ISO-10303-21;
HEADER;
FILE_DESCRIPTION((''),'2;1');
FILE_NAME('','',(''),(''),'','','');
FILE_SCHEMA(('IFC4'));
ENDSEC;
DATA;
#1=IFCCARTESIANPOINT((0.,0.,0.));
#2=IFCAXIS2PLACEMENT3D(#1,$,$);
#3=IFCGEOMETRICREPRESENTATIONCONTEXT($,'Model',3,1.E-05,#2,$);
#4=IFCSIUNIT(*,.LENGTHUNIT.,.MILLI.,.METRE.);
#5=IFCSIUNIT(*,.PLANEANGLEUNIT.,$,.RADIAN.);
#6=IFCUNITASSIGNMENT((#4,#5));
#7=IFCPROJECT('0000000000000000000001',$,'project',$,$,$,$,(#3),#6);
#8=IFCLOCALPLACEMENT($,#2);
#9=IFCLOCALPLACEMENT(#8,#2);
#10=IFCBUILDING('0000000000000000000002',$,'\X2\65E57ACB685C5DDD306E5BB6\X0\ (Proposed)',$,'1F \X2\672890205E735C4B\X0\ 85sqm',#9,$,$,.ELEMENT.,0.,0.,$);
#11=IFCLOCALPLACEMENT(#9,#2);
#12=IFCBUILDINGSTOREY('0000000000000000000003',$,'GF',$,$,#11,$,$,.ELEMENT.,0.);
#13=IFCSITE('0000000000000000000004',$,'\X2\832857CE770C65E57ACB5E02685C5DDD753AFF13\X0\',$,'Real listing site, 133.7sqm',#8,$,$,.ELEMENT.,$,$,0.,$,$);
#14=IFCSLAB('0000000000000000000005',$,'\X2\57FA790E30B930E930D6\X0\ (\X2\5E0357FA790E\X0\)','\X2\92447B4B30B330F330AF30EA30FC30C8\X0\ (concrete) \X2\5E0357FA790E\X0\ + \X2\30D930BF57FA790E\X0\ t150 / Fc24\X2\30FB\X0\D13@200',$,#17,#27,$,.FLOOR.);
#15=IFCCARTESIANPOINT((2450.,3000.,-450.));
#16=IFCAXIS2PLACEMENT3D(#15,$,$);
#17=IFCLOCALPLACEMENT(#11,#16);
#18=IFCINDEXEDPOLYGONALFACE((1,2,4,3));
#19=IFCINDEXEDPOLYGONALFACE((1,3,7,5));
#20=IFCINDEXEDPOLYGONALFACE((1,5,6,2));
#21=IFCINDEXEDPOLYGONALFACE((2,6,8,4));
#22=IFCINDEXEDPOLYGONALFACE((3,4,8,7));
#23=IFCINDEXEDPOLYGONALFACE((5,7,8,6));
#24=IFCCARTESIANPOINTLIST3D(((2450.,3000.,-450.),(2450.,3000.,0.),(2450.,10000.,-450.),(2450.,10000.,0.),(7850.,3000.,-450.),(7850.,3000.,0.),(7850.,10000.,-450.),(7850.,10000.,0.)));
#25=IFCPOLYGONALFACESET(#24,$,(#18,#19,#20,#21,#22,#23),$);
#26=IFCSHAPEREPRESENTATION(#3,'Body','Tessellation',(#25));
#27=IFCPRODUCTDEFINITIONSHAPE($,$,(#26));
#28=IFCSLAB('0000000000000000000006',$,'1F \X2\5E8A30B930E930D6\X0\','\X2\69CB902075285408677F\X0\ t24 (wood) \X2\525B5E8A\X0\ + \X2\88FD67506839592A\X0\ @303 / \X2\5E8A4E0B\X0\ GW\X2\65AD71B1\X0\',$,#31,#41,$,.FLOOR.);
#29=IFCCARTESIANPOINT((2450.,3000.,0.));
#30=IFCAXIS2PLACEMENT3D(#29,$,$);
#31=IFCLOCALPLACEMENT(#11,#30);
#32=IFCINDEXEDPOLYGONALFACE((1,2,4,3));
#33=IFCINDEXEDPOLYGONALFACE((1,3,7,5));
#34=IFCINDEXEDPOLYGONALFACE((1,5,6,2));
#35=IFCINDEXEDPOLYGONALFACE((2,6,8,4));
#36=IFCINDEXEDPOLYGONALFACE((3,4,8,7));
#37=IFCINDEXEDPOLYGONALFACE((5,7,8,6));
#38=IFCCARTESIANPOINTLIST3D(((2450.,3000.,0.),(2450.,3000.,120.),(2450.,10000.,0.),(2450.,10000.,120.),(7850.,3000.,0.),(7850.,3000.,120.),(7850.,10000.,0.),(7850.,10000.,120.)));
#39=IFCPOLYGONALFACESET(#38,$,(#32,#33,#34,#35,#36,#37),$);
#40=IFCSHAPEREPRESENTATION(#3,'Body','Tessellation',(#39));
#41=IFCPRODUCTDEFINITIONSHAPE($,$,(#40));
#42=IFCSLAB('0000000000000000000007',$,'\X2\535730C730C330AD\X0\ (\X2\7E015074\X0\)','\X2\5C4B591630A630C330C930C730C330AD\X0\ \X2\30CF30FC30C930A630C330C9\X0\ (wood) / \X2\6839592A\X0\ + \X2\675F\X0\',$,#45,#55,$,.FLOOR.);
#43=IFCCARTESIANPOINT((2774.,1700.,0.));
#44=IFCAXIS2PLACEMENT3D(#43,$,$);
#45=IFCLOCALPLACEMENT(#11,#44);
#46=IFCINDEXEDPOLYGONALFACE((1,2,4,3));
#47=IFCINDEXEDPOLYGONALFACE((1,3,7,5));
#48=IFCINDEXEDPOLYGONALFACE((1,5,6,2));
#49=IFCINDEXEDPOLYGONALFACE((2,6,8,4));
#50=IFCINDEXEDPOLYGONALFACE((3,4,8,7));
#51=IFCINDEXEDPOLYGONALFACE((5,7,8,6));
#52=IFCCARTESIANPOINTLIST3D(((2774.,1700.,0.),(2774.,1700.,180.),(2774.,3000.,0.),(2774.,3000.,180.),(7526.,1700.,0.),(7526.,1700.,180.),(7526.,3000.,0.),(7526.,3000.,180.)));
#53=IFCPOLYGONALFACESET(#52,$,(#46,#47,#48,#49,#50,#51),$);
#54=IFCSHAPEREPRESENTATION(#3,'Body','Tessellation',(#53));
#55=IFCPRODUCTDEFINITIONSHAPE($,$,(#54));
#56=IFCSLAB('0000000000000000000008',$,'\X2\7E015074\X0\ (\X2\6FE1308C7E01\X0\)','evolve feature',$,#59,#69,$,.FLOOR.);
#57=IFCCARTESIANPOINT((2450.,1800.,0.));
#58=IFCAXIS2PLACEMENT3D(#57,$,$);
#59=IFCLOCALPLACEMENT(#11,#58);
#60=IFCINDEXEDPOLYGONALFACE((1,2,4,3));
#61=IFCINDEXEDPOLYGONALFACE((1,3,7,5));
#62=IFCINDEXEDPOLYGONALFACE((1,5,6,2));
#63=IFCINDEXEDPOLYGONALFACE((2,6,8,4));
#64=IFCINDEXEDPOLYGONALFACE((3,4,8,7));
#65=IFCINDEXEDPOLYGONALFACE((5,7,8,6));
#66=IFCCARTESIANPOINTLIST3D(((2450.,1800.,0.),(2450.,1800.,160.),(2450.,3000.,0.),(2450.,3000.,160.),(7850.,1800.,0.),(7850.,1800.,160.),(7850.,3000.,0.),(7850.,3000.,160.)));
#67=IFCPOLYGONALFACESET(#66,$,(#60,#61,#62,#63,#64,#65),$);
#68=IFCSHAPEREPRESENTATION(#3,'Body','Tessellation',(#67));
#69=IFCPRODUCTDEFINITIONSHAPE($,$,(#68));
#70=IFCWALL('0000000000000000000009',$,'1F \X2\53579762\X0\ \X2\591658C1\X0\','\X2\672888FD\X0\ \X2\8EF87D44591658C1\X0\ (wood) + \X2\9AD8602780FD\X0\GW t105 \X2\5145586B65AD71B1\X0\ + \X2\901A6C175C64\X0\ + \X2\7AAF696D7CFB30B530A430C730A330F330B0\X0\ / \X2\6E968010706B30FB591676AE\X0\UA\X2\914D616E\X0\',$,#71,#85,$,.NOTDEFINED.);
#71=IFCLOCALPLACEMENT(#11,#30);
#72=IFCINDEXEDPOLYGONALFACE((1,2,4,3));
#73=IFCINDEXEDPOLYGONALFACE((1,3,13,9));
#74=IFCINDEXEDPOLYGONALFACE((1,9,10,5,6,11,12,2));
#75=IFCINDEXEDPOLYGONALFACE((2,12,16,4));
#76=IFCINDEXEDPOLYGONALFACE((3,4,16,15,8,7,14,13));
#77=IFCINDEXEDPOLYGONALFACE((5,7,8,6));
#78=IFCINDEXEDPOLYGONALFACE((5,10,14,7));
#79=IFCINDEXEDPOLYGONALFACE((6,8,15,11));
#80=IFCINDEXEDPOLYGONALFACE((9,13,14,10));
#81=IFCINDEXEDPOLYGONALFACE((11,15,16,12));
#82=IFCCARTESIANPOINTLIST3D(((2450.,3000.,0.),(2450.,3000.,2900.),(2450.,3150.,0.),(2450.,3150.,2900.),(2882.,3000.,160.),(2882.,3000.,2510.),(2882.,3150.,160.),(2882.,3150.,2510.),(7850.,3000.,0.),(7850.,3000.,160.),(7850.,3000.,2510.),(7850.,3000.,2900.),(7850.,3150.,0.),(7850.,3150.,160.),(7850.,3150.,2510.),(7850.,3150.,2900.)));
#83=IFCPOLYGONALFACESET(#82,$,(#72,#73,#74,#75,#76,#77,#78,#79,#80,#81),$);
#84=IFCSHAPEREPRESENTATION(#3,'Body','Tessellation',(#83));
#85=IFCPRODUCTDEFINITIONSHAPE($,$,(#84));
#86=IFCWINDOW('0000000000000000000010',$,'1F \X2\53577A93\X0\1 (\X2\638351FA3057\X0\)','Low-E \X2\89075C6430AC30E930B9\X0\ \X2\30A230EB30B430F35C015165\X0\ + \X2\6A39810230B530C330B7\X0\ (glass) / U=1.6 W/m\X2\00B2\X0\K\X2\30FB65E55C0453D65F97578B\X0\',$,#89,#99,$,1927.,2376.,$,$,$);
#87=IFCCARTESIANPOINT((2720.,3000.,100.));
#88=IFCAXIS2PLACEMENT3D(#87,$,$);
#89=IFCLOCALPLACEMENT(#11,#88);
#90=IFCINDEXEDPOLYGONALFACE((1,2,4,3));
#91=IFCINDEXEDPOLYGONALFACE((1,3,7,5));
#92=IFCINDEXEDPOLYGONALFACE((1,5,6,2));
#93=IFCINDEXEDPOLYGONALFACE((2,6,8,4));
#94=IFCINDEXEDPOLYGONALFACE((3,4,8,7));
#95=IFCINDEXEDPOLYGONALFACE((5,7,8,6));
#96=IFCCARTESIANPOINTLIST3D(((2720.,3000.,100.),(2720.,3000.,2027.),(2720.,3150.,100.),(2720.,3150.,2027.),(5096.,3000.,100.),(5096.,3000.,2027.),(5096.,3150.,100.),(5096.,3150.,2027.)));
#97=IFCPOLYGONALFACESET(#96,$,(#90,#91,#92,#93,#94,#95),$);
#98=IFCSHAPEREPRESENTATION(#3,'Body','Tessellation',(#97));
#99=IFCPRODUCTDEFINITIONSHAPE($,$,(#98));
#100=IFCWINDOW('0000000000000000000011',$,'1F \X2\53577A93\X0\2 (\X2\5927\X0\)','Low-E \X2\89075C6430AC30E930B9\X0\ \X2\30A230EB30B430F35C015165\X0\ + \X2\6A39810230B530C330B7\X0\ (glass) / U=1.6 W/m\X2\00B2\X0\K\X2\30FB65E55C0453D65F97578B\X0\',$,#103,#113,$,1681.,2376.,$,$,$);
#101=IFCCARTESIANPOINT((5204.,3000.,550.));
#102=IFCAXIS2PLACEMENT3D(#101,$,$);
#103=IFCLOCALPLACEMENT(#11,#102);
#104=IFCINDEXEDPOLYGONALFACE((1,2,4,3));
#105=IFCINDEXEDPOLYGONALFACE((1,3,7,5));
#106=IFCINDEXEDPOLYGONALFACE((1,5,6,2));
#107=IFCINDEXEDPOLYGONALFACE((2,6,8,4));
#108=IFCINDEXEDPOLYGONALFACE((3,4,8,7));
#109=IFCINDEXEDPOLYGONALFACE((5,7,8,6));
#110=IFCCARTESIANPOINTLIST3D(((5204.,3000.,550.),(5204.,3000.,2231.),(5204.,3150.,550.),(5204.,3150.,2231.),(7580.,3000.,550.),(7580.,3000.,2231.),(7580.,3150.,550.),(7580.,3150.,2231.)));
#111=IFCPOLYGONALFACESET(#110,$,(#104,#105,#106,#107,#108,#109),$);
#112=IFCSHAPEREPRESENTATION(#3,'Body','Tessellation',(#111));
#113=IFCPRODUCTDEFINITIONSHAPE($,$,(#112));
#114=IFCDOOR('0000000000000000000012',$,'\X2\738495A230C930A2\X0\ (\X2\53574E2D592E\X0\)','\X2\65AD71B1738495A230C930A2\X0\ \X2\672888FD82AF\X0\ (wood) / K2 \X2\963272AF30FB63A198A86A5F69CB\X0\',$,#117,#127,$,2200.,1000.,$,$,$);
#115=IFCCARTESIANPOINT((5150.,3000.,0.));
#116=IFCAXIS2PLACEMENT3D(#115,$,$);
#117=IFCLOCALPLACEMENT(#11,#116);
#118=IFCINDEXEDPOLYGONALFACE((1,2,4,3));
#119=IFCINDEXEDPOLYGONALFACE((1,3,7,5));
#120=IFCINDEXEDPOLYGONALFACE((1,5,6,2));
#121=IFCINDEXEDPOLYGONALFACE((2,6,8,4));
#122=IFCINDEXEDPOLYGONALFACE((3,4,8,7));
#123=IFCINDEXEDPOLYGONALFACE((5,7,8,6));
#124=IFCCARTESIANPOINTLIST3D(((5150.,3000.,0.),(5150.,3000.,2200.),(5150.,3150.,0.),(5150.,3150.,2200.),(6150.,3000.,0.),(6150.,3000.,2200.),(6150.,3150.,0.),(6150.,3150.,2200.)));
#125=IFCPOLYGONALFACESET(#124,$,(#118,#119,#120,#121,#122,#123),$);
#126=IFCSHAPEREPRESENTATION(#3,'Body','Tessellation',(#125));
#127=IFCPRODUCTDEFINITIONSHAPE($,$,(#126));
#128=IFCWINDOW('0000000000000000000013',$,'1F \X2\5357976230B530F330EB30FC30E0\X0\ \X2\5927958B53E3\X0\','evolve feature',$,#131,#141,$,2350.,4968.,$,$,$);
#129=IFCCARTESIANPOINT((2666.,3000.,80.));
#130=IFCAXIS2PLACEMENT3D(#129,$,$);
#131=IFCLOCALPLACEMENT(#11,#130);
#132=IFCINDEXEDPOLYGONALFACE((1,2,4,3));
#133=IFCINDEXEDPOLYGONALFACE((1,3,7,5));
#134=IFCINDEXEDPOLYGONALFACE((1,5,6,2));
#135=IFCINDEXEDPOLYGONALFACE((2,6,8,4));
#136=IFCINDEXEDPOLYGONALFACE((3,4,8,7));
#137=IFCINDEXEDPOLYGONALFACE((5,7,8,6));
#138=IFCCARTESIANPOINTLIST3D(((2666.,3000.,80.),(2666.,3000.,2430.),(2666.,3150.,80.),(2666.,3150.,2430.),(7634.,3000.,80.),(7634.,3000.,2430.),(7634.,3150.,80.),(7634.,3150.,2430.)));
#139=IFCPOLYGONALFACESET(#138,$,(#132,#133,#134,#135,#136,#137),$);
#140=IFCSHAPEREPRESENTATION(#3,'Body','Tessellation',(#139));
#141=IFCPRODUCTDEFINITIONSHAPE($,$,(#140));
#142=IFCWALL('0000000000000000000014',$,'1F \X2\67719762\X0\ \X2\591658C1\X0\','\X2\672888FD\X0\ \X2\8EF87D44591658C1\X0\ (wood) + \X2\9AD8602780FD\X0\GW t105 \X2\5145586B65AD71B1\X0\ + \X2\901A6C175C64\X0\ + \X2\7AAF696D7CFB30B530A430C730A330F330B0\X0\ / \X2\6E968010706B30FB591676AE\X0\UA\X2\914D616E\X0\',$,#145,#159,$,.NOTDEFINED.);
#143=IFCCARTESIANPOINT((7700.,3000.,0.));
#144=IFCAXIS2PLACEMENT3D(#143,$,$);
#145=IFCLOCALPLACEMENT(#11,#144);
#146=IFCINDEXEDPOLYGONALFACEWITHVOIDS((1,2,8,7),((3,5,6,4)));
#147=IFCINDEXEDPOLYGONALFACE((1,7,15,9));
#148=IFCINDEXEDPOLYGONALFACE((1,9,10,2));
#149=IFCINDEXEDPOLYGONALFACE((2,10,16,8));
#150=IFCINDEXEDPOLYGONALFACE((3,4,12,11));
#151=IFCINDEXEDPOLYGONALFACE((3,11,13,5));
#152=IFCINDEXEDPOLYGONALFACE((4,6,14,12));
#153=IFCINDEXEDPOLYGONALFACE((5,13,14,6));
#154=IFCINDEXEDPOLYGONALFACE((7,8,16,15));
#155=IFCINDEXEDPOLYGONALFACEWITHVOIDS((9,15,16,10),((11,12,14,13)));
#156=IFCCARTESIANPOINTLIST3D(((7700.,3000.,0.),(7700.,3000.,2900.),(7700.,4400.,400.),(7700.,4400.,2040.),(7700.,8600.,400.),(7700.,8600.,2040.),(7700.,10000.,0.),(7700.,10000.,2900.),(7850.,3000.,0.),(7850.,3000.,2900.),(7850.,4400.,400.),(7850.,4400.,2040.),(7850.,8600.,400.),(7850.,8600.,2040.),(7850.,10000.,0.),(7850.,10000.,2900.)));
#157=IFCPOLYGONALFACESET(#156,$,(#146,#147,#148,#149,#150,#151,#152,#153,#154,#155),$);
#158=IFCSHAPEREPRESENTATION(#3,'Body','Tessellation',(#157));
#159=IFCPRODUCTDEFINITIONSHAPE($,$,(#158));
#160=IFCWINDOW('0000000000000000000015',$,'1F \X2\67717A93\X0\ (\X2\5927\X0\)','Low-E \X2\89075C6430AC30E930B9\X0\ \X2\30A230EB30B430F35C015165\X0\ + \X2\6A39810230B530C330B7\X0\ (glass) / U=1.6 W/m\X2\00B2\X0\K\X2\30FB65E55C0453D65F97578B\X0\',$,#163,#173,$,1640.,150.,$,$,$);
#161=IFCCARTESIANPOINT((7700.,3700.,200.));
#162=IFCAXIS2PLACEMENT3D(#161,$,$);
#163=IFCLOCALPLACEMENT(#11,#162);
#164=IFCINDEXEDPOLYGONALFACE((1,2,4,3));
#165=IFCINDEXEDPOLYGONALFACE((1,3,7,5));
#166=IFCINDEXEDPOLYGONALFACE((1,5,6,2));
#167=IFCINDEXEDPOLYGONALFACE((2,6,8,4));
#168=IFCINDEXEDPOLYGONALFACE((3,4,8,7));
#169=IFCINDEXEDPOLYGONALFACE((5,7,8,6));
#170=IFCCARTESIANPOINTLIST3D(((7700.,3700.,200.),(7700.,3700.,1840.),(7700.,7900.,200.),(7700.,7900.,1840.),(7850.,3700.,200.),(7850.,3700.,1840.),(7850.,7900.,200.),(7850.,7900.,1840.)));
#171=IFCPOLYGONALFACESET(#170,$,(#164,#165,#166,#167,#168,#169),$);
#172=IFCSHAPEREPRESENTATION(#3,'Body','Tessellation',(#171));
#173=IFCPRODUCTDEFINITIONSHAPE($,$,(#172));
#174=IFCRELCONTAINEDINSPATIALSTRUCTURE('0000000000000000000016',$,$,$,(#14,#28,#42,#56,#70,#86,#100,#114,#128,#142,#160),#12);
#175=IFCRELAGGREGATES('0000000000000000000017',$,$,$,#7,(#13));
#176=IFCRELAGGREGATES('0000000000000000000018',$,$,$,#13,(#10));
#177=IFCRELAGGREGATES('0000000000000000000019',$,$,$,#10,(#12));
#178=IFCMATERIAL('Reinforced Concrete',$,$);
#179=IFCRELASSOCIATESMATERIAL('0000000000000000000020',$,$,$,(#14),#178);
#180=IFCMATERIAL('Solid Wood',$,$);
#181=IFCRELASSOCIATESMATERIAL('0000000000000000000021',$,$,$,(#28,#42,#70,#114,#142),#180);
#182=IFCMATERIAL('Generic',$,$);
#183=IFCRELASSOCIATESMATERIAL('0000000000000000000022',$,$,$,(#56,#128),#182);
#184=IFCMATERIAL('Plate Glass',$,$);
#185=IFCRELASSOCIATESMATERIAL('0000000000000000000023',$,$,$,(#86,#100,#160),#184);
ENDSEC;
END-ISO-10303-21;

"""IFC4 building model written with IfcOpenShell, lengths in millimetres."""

from ifc_helpers import new_model, si_unit, frame, frame_2d, origin, place, context, project, spatial, rectangle, extrude, material, element, fill, save


model = new_model("IFC4")

# Units and contexts
model_context = context("Model", 3, precision=1e-05, world=origin())
ifc_project = project(units=[si_unit("LENGTHUNIT", "METRE", prefix="MILLI"), si_unit("PLANEANGLEUNIT", "RADIAN")], contexts=[model_context])

# Site, building, storey
site_placement = place(None, origin())
site = spatial("IfcSite", under=ifc_project, at=site_placement, Name="茨城県日立市桜川町３", ObjectType="Real listing site, 133.7sqm", CompositionType="ELEMENT", RefElevation=0.0)
building_placement = place(site_placement, origin())
building = spatial("IfcBuilding", under=site, at=building_placement, Name="日立桜川の家 (Proposed)", ObjectType="1F 木造平屋 85sqm", CompositionType="ELEMENT", ElevationOfRefHeight=0.0, ElevationOfTerrain=0.0)
storey_placement = place(building_placement, origin())
storey = spatial("IfcBuildingStorey", under=building, at=storey_placement, Name="GF", CompositionType="ELEMENT", Elevation=0.0)

# Slabs
ifc_material_1 = material(Name="Reinforced Concrete")
slab_1_placement = place(storey_placement, frame((2450.0, 3000.0, -450.0)))
element("IfcSlab", 1, at=slab_1_placement, inside=storey, material=ifc_material_1, Name="基礎スラブ (布基礎)", Description="鉄筋コンクリート (concrete) 布基礎 + ベタ基礎 t150 / Fc24・D13@200", PredefinedType="FLOOR", context=model_context, shape_type="SweptSolid", body=[
    extrude(rectangle(XDim=5400.0, YDim=7000.0, at=frame_2d((2700.0, 3500.0))), frame((2450.0, 3000.0, -450.0)), (0.0, 0.0, 1.0), 450.0),
])
ifc_material_2 = material(Name="Solid Wood")
slab_2_placement = place(storey_placement, frame((2450.0, 3000.0, 0.0)))
element("IfcSlab", 2, at=slab_2_placement, inside=storey, material=ifc_material_2, Name="1F 床スラブ", Description="構造用合板 t24 (wood) 剛床 + 製材根太 @303 / 床下 GW断熱", PredefinedType="FLOOR", context=model_context, shape_type="SweptSolid", body=[
    extrude(rectangle(XDim=5400.0, YDim=7000.0, at=frame_2d((2700.0, 3500.0))), frame((2450.0, 3000.0, 0.0)), (0.0, 0.0, 1.0), 120.0),
])
slab_3_placement = place(storey_placement, frame((2774.0, 1700.0, 0.0)))
element("IfcSlab", 3, at=slab_3_placement, inside=storey, material=ifc_material_2, Name="南デッキ (縁側)", Description="屋外ウッドデッキ ハードウッド (wood) / 根太 + 束", PredefinedType="FLOOR", context=model_context, shape_type="SweptSolid", body=[
    extrude(rectangle(XDim=4752.0, YDim=1300.0, at=frame_2d((2376.0, 650.0))), frame((2774.0, 1700.0, 0.0)), (0.0, 0.0, 1.0), 180.0),
])
ifc_material_3 = material(Name="Generic")
slab_4_placement = place(storey_placement, frame((2450.0, 1800.0, 0.0)))
element("IfcSlab", 4, at=slab_4_placement, inside=storey, material=ifc_material_3, Name="縁側 (濡れ縁)", Description="evolve feature", PredefinedType="FLOOR", context=model_context, shape_type="SweptSolid", body=[
    extrude(rectangle(XDim=5400.0, YDim=1200.0, at=frame_2d((2700.0, 600.0))), frame((2450.0, 1800.0, 0.0)), (0.0, 0.0, 1.0), 160.0),
])

# Wall, openings, windows, door
wall_1_placement = place(storey_placement, frame((2450.0, 3000.0, 0.0)))
wall_1 = element("IfcWall", 5, at=wall_1_placement, inside=storey, material=ifc_material_2, Name="1F 南面 外壁", Description="木製 軸組外壁 (wood) + 高性能GW t105 充填断熱 + 通気層 + 窯業系サイディング / 準耐火・外皮UA配慮", PredefinedType="NOTDEFINED", context=model_context, shape_type="SweptSolid", body=[
    extrude(rectangle(XDim=5400.0, YDim=150.0, at=frame_2d((2700.0, 75.0))), frame((2450.0, 3000.0, 0.0)), (0.0, 0.0, 1.0), 2900.0),
])
opening_1_placement = place(storey_placement, frame((2720.0, 3000.0, 100.0)))
opening_1 = element("IfcOpeningElement", 6, at=opening_1_placement, cuts=wall_1, PredefinedType="NOTDEFINED", context=model_context, shape_type="SweptSolid", body=[
    extrude(rectangle(XDim=2376.0, YDim=150.0, at=frame_2d((1188.0, 75.0))), frame((2720.0, 3000.0, 100.0)), (0.0, 0.0, 1.0), 1927.0),
])
opening_2_placement = place(storey_placement, frame((5204.0, 3000.0, 550.0)))
opening_2 = element("IfcOpeningElement", 7, at=opening_2_placement, cuts=wall_1, PredefinedType="NOTDEFINED", context=model_context, shape_type="SweptSolid", body=[
    extrude(rectangle(XDim=2376.0, YDim=150.0, at=frame_2d((1188.0, 75.0))), frame((5204.0, 3000.0, 550.0)), (0.0, 0.0, 1.0), 1681.0),
])
opening_3_placement = place(storey_placement, frame((5150.0, 3000.0, 0.0)))
opening_3 = element("IfcOpeningElement", 8, at=opening_3_placement, cuts=wall_1, PredefinedType="NOTDEFINED", context=model_context, shape_type="SweptSolid", body=[
    extrude(rectangle(XDim=1000.0, YDim=150.0, at=frame_2d((500.0, 75.0))), frame((5150.0, 3000.0, 0.0)), (0.0, 0.0, 1.0), 2200.0),
])
opening_4_placement = place(storey_placement, frame((2666.0, 3000.0, 80.0)))
opening_4 = element("IfcOpeningElement", 9, at=opening_4_placement, cuts=wall_1, PredefinedType="NOTDEFINED", context=model_context, shape_type="SweptSolid", body=[
    extrude(rectangle(XDim=4968.0, YDim=150.0, at=frame_2d((2484.0, 75.0))), frame((2666.0, 3000.0, 80.0)), (0.0, 0.0, 1.0), 2350.0),
])
ifc_material_4 = material(Name="Plate Glass")
window_1_placement = place(storey_placement, frame((2720.0, 3000.0, 100.0)))
window_1 = element("IfcWindow", 10, at=window_1_placement, inside=storey, material=ifc_material_4, Name="1F 南窓1 (掃出し)", Description="Low-E 複層ガラス アルゴン封入 + 樹脂サッシ (glass) / U=1.6 W/m²K・日射取得型", OverallHeight=1927.0, OverallWidth=2376.0, context=model_context, shape_type="SweptSolid", body=[
    extrude(rectangle(XDim=2376.0, YDim=150.0, at=frame_2d((1188.0, 75.0))), frame((2720.0, 3000.0, 100.0)), (0.0, 0.0, 1.0), 1927.0),
])
fill(opening_1, window_1)
window_2_placement = place(storey_placement, frame((5204.0, 3000.0, 550.0)))
window_2 = element("IfcWindow", 11, at=window_2_placement, inside=storey, material=ifc_material_4, Name="1F 南窓2 (大)", Description="Low-E 複層ガラス アルゴン封入 + 樹脂サッシ (glass) / U=1.6 W/m²K・日射取得型", OverallHeight=1681.0, OverallWidth=2376.0, context=model_context, shape_type="SweptSolid", body=[
    extrude(rectangle(XDim=2376.0, YDim=150.0, at=frame_2d((1188.0, 75.0))), frame((5204.0, 3000.0, 550.0)), (0.0, 0.0, 1.0), 1681.0),
])
fill(opening_2, window_2)
door_placement = place(storey_placement, frame((5150.0, 3000.0, 0.0)))
door = element("IfcDoor", 12, at=door_placement, inside=storey, material=ifc_material_2, Name="玄関ドア (南中央)", Description="断熱玄関ドア 木製芯 (wood) / K2 防犯・採風機構", OverallHeight=2200.0, OverallWidth=1000.0, context=model_context, shape_type="SweptSolid", body=[
    extrude(rectangle(XDim=1000.0, YDim=150.0, at=frame_2d((500.0, 75.0))), frame((5150.0, 3000.0, 0.0)), (0.0, 0.0, 1.0), 2200.0),
])
fill(opening_3, door)
window_3_placement = place(storey_placement, frame((2666.0, 3000.0, 80.0)))
window_3 = element("IfcWindow", 13, at=window_3_placement, inside=storey, material=ifc_material_3, Name="1F 南面サンルーム 大開口", Description="evolve feature", OverallHeight=2350.0, OverallWidth=4968.0, context=model_context, shape_type="SweptSolid", body=[
    extrude(rectangle(XDim=4968.0, YDim=150.0, at=frame_2d((2484.0, 75.0))), frame((2666.0, 3000.0, 80.0)), (0.0, 0.0, 1.0), 2350.0),
])
fill(opening_4, window_3)

# Wall, opening, window
wall_2_placement = place(storey_placement, frame((7700.0, 3000.0, 0.0)))
wall_2 = element("IfcWall", 14, at=wall_2_placement, inside=storey, material=ifc_material_2, Name="1F 東面 外壁", Description="木製 軸組外壁 (wood) + 高性能GW t105 充填断熱 + 通気層 + 窯業系サイディング / 準耐火・外皮UA配慮", PredefinedType="NOTDEFINED", context=model_context, shape_type="SweptSolid", body=[
    extrude(rectangle(XDim=150.0, YDim=7000.0, at=frame_2d((75.0, 3500.0))), frame((7700.0, 3000.0, 0.0)), (0.0, 0.0, 1.0), 2900.0),
])
opening_5_placement = place(storey_placement, frame((7700.0, 3700.0, 200.0)))
opening_5 = element("IfcOpeningElement", 15, at=opening_5_placement, cuts=wall_2, PredefinedType="NOTDEFINED", context=model_context, shape_type="SweptSolid", body=[
    extrude(rectangle(XDim=150.0, YDim=4200.0, at=frame_2d((75.0, 2100.0))), frame((7700.0, 3700.0, 200.0)), (0.0, 0.0, 1.0), 1640.0),
])
window_4_placement = place(storey_placement, frame((7700.0, 3700.0, 200.0)))
window_4 = element("IfcWindow", 16, at=window_4_placement, inside=storey, material=ifc_material_4, Name="1F 東窓 (大)", Description="Low-E 複層ガラス アルゴン封入 + 樹脂サッシ (glass) / U=1.6 W/m²K・日射取得型", OverallHeight=1640.0, OverallWidth=150.0, context=model_context, shape_type="SweptSolid", body=[
    extrude(rectangle(XDim=150.0, YDim=4200.0, at=frame_2d((75.0, 2100.0))), frame((7700.0, 3700.0, 200.0)), (0.0, 0.0, 1.0), 1640.0),
])
fill(opening_5, window_4)

save(model, "model.ifc")
